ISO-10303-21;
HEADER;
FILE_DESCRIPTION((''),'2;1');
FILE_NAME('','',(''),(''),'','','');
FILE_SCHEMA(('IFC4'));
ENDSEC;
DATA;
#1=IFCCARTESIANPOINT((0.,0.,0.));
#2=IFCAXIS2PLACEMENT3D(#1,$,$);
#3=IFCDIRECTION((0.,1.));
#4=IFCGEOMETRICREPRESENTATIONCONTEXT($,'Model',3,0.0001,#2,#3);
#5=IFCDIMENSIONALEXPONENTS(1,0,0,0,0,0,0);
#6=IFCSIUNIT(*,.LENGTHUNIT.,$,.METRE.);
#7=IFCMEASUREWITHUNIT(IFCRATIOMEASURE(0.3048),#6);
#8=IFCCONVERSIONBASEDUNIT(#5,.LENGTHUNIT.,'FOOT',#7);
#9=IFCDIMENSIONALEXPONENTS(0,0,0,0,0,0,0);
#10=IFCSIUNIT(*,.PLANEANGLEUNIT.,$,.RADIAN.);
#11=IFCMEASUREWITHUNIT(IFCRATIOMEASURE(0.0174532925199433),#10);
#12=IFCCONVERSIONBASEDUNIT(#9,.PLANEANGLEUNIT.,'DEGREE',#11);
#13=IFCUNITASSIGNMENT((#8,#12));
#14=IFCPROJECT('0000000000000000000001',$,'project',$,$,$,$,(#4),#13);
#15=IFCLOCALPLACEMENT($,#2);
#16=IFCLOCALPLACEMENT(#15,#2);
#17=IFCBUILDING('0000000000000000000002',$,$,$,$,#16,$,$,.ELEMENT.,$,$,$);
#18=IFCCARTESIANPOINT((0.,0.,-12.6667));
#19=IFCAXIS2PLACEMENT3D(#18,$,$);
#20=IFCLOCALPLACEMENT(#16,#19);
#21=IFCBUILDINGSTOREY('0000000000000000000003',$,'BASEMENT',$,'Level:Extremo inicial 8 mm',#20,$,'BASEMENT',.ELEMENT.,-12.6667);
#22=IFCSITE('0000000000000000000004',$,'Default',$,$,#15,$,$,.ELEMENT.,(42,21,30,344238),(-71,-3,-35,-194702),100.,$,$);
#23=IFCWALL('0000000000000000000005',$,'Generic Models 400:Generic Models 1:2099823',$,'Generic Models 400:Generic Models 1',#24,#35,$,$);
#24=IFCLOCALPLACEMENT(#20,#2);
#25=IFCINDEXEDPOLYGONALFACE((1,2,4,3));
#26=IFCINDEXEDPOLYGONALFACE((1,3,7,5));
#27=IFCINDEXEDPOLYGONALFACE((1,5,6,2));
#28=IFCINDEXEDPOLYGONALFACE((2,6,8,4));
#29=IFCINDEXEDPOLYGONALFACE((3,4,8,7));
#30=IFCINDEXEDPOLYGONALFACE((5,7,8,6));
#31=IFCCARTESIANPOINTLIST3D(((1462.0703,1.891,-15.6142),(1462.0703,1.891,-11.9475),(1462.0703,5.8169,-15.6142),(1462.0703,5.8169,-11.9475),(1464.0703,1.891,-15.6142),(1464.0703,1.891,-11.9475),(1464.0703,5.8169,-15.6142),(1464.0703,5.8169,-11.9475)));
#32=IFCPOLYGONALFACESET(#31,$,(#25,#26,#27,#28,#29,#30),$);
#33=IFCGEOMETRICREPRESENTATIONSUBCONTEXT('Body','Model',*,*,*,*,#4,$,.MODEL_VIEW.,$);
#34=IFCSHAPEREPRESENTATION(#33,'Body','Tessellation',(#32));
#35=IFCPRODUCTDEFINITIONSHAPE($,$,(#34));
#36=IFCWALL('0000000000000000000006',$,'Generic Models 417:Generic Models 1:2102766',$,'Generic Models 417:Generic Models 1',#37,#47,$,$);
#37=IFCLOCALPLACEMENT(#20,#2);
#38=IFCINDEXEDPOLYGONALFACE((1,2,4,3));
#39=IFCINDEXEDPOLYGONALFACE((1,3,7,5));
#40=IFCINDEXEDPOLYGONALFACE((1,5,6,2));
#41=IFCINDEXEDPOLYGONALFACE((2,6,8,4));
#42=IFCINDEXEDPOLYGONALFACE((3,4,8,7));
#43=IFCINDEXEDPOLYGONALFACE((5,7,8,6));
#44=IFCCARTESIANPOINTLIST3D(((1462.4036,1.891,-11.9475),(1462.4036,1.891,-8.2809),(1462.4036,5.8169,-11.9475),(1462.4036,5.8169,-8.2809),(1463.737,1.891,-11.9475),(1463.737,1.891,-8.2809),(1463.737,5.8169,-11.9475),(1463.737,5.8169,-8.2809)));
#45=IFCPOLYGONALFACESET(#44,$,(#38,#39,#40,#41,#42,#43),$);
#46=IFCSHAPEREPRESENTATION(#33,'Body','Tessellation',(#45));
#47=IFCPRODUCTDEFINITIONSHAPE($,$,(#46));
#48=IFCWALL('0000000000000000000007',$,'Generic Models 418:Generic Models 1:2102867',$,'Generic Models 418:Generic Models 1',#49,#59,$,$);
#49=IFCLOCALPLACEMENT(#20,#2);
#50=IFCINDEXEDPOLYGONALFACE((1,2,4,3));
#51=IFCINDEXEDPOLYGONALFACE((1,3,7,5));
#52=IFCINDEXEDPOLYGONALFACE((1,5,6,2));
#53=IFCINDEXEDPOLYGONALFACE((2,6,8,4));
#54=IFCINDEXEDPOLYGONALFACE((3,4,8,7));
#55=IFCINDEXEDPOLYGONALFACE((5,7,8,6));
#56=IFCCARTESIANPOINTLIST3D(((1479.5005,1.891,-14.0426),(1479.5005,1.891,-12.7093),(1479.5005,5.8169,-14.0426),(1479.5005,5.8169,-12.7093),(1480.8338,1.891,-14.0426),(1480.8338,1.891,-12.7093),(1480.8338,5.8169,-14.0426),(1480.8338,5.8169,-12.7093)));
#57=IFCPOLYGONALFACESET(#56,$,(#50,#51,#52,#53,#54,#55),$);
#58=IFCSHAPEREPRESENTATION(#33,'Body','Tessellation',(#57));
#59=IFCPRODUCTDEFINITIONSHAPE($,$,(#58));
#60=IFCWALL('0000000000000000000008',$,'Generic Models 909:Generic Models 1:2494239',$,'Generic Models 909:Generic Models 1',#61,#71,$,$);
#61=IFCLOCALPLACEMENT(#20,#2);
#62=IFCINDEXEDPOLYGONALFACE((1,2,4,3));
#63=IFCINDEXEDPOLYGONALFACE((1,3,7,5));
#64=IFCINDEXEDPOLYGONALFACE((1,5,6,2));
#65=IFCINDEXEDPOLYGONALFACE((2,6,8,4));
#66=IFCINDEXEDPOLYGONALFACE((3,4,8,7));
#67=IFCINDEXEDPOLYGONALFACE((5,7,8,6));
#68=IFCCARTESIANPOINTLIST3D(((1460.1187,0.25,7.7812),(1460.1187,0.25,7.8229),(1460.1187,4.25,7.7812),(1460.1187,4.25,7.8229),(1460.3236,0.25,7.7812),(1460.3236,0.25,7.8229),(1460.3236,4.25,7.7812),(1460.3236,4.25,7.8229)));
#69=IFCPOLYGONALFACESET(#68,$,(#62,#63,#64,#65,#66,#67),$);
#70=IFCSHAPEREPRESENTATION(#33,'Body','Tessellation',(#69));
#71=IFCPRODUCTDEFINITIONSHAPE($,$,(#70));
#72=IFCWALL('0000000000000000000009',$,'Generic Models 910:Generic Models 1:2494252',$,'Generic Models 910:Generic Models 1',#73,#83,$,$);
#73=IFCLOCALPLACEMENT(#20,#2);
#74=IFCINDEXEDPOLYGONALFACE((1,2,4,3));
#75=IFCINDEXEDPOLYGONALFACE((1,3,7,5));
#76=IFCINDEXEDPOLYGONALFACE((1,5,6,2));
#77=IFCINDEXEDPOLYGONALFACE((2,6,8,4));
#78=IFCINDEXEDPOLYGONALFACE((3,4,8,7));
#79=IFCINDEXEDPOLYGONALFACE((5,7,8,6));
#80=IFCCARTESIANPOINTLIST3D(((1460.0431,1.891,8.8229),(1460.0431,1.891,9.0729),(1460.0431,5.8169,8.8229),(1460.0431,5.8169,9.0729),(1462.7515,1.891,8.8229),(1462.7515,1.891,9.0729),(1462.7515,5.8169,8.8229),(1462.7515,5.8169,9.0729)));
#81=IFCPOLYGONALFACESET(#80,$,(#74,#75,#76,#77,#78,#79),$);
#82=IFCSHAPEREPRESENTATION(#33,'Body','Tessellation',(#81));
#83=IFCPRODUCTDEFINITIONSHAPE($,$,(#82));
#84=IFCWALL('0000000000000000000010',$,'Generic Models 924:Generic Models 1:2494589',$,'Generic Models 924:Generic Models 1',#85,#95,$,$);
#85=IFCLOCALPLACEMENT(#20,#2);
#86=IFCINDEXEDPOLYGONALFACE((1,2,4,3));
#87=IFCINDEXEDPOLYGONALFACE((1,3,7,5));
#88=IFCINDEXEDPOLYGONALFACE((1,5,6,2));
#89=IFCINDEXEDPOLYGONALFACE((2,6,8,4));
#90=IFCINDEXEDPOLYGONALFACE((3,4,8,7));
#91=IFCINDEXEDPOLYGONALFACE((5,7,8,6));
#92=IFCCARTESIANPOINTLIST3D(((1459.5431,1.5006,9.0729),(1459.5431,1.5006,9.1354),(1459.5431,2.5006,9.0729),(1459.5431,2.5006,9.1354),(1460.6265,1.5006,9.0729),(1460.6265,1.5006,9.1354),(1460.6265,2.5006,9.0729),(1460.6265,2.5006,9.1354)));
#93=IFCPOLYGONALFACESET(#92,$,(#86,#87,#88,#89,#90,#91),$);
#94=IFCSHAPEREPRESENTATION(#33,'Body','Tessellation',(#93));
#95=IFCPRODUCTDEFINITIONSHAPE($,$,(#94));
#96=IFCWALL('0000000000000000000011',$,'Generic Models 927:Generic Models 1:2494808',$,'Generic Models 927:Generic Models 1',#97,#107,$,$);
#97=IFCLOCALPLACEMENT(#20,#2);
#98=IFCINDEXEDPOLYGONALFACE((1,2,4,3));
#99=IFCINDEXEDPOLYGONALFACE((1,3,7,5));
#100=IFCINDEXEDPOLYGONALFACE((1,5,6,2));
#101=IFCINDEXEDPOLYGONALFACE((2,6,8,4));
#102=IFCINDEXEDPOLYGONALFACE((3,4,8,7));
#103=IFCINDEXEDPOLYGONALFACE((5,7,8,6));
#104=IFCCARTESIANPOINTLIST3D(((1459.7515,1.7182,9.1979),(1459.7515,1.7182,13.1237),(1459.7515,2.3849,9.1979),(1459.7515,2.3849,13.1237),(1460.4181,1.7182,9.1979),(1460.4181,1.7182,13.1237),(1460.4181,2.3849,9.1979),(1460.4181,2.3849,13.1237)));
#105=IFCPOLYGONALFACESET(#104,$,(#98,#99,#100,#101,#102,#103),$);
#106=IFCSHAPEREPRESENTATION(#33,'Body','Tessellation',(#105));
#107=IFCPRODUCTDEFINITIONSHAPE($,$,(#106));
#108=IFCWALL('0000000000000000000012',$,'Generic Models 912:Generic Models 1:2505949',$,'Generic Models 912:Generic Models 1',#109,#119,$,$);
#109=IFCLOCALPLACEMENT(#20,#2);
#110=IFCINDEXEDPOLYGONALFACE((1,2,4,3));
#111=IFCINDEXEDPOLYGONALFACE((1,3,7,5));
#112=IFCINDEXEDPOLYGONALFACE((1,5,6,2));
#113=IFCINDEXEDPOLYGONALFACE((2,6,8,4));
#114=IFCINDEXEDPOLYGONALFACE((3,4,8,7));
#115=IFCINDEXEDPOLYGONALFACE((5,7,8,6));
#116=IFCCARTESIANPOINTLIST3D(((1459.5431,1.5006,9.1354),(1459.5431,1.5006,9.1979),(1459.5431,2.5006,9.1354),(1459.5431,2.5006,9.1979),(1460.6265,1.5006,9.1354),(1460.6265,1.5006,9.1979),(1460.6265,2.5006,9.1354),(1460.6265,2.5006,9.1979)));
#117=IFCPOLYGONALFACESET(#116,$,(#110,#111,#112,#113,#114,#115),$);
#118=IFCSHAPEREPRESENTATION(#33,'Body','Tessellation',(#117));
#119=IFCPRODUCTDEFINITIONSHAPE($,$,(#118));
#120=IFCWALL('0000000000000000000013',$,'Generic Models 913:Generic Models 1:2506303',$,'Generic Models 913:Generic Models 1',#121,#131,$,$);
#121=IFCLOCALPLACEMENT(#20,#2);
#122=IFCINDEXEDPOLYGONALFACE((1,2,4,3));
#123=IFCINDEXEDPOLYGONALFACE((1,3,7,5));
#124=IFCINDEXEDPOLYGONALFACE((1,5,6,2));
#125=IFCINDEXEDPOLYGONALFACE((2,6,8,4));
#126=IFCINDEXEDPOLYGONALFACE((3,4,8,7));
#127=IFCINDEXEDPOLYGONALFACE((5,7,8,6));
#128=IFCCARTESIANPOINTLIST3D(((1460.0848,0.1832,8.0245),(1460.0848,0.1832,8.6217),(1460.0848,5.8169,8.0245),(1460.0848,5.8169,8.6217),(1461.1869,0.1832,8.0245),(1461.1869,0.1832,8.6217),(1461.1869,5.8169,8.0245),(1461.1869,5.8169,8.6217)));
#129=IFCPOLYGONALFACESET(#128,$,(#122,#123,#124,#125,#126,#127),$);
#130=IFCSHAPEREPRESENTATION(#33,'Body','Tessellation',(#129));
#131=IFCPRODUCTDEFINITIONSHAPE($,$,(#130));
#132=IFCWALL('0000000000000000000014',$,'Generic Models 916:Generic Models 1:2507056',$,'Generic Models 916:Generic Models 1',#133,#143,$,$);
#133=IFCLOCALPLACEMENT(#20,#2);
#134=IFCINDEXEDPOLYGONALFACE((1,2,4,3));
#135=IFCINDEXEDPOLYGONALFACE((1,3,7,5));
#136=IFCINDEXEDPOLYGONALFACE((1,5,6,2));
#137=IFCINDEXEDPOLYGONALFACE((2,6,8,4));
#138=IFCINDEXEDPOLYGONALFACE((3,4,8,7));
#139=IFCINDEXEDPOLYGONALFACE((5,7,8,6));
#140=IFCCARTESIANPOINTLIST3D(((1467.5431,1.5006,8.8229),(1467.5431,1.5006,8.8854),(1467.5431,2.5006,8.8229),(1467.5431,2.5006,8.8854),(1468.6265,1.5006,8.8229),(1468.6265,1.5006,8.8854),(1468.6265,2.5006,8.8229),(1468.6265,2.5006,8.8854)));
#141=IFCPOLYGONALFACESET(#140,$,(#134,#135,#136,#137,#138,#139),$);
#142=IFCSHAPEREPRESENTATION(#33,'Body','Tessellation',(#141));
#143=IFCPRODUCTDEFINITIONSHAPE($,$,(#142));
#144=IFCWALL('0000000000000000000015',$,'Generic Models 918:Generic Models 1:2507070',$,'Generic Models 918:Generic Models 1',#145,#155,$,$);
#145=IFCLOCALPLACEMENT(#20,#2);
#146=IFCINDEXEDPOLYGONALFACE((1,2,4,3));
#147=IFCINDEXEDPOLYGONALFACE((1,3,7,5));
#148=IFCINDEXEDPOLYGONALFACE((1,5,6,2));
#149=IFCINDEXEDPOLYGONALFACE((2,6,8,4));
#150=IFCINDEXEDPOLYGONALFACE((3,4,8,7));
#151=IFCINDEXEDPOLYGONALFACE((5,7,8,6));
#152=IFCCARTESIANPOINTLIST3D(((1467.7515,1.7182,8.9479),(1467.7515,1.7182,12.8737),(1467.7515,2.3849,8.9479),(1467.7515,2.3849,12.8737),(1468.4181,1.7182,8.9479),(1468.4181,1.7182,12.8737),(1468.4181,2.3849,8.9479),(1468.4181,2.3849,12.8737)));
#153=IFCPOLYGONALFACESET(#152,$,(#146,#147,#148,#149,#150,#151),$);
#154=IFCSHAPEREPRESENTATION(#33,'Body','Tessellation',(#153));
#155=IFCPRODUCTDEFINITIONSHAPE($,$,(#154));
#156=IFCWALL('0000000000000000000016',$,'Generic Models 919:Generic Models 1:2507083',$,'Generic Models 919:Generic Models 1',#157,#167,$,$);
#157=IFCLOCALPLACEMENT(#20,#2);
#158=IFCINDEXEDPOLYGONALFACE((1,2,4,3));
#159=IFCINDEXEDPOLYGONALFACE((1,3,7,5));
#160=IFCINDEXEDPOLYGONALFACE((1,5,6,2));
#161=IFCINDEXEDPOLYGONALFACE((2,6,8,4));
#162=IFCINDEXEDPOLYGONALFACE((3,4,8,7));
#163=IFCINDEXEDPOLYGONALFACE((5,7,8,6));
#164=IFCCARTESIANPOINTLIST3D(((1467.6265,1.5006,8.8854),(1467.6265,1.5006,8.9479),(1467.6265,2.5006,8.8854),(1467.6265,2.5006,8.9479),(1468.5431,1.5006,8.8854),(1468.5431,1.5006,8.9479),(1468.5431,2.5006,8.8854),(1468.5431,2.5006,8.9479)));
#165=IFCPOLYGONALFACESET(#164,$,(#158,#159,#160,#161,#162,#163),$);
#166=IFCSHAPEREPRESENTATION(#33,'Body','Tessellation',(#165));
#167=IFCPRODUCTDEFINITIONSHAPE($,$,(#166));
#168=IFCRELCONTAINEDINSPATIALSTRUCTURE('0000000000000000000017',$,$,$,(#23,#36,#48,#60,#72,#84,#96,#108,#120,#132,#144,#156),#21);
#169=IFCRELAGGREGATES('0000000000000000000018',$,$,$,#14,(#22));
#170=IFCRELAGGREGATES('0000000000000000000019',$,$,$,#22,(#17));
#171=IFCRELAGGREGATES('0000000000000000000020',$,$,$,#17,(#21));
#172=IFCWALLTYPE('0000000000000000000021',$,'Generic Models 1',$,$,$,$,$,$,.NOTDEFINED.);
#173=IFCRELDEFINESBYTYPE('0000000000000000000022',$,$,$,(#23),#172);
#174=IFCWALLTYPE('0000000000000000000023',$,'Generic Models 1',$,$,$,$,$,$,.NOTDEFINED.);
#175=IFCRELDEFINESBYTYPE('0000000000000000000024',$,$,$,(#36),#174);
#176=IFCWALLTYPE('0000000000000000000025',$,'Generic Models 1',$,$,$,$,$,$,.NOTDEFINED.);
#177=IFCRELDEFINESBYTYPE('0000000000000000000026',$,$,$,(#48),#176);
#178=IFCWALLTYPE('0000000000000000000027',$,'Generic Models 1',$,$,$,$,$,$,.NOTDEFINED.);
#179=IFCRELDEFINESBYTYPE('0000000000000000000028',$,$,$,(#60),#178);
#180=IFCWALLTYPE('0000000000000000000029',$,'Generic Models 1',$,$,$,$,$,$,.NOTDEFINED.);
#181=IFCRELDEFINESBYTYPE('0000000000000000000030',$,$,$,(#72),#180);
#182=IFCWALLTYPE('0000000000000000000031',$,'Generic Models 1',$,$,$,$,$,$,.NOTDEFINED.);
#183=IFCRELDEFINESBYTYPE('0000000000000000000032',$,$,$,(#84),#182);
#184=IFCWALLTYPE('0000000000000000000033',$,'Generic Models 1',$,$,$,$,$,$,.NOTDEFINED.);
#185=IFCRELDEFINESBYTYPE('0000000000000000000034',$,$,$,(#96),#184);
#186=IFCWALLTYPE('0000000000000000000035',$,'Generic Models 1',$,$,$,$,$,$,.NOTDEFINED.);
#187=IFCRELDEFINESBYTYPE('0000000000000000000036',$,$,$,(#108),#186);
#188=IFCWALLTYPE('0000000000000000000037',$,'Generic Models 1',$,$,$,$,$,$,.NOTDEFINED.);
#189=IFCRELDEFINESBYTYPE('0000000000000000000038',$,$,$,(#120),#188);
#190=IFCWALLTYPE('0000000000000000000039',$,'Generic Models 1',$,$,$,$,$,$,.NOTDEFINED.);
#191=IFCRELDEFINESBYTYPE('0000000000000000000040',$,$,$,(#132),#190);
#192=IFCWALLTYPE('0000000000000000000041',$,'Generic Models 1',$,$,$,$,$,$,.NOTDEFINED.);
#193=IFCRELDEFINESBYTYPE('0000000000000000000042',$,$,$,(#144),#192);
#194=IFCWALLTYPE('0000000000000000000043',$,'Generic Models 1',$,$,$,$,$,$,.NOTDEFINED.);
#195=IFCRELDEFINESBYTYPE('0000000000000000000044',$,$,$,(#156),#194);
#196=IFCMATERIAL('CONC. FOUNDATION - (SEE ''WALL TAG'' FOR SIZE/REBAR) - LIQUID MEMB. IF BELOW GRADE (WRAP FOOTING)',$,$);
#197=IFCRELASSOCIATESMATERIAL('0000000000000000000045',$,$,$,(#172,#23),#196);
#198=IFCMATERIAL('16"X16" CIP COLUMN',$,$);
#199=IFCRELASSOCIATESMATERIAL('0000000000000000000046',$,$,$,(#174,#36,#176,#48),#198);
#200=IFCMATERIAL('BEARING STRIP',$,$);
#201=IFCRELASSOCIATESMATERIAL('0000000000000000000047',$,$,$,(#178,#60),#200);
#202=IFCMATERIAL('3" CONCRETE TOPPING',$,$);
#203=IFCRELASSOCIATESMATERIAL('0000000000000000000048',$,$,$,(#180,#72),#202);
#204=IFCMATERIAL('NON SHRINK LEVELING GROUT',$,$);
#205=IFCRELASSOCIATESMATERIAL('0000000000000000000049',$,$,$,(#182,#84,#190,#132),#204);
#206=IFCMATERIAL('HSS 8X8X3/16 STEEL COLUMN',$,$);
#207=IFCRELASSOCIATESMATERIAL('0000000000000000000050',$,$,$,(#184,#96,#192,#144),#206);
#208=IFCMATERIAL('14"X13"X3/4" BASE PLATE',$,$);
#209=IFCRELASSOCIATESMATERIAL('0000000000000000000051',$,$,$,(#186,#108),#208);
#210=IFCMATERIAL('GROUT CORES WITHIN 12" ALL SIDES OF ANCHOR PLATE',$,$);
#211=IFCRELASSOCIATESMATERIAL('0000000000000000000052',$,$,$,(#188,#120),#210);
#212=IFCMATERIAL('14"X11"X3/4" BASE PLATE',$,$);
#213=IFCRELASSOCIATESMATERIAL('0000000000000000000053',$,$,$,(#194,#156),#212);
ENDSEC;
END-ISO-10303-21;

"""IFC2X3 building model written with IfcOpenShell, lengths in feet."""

from ifc_helpers import new_model, entity, si_unit, converted_unit, direction, frame, frame_2d, origin, place, context, subcontext, project, spatial, rectangle, extrude, material, type_object, element, save


model = new_model("IFC2X3")

# Units and contexts
model_context = context("Model", 3, precision=0.0001, world=origin(), true_north=direction((0.0, 1.0)))
body_context = subcontext(model_context, "Body", "Model", "MODEL_VIEW")
ifc_project = project(units=[converted_unit("LENGTHUNIT", "FOOT", entity("IfcRatioMeasure", 0.3048), si_unit("LENGTHUNIT", "METRE"), dimensions=[1, 0, 0, 0, 0, 0, 0]), converted_unit("PLANEANGLEUNIT", "DEGREE", entity("IfcRatioMeasure", 0.0174532925199433), si_unit("PLANEANGLEUNIT", "RADIAN"), dimensions=[0, 0, 0, 0, 0, 0, 0])], contexts=[model_context])

# Site, building, storey
site_placement = place(None, origin())
site = spatial("IfcSite", under=ifc_project, at=site_placement, Name="Default", CompositionType="ELEMENT", RefLatitude=(42, 21, 30, 344238), RefLongitude=(-71, -3, -35, -194702), RefElevation=100.0)
building_placement = place(site_placement, origin())
building = spatial("IfcBuilding", under=site, at=building_placement, CompositionType="ELEMENT")
storey_placement = place(building_placement, frame((0.0, 0.0, -12.6667)))
storey = spatial("IfcBuildingStorey", under=building, at=storey_placement, Name="BASEMENT", ObjectType="Level:Extremo inicial 8 mm", LongName="BASEMENT", CompositionType="ELEMENT", Elevation=-12.6667)

# Walls
ifc_material_1 = material(Name="CONC. FOUNDATION - (SEE 'WALL TAG' FOR SIZE/REBAR) - LIQUID MEMB. IF BELOW GRADE (WRAP FOOTING)")
wall_type_1 = type_object("IfcWallType", Name="Generic Models 1", PredefinedType="NOTDEFINED", material=ifc_material_1)
wall_1_placement = place(storey_placement, frame((1462.0703, 1.891, -15.6142), z_axis=(0.0, 0.0, 1.0), x_axis=(0.0, 1.0, 0.0)))
element("IfcWall", 1, at=wall_1_placement, inside=storey, type_object=wall_type_1, material=ifc_material_1, Name="Generic Models 400:Generic Models 1:2099823", ObjectType="Generic Models 400:Generic Models 1", context=body_context, shape_type="SweptSolid", body=[
    extrude(rectangle(XDim=3.9258, YDim=2.0, at=frame_2d((0.0, 0.0), x_axis=(1.0, 0.0))), frame((1.9629, -1.0, 0.0)), (0.0, 0.0, 1.0), 3.6667),
])
ifc_material_2 = material(Name="16\"X16\" CIP COLUMN")
wall_type_2 = type_object("IfcWallType", Name="Generic Models 1", PredefinedType="NOTDEFINED", material=ifc_material_2)
wall_2_placement = place(storey_placement, frame((1462.4036, 1.891, -11.9475), z_axis=(0.0, 0.0, 1.0), x_axis=(0.0, 1.0, 0.0)))
element("IfcWall", 2, at=wall_2_placement, inside=storey, type_object=wall_type_2, material=ifc_material_2, Name="Generic Models 417:Generic Models 1:2102766", ObjectType="Generic Models 417:Generic Models 1", context=body_context, shape_type="SweptSolid", body=[
    extrude(rectangle(XDim=3.9258, YDim=1.3333, at=frame_2d((0.0, 0.0), x_axis=(1.0, 0.0))), frame((1.9629, -0.6667, 0.0)), (0.0, 0.0, 1.0), 3.6667),
])
wall_type_3 = type_object("IfcWallType", Name="Generic Models 1", PredefinedType="NOTDEFINED", material=ifc_material_2)
wall_3_placement = place(storey_placement, frame((1479.5005, 1.891, -14.0426), z_axis=(0.0, 0.0, 1.0), x_axis=(0.0, 1.0, 0.0)))
element("IfcWall", 3, at=wall_3_placement, inside=storey, type_object=wall_type_3, material=ifc_material_2, Name="Generic Models 418:Generic Models 1:2102867", ObjectType="Generic Models 418:Generic Models 1", context=body_context, shape_type="SweptSolid", body=[
    extrude(rectangle(XDim=3.9258, YDim=1.3333, at=frame_2d((0.0, 0.0), x_axis=(1.0, 0.0))), frame((1.9629, -0.6667, 0.0)), (0.0, 0.0, 1.0), 1.3333),
])
ifc_material_3 = material(Name="BEARING STRIP")
wall_type_4 = type_object("IfcWallType", Name="Generic Models 1", PredefinedType="NOTDEFINED", material=ifc_material_3)
wall_4_placement = place(storey_placement, frame((1460.1187, 0.25, 7.7812), z_axis=(0.0, 0.0, 1.0), x_axis=(0.0, 1.0, 0.0)))
element("IfcWall", 4, at=wall_4_placement, inside=storey, type_object=wall_type_4, material=ifc_material_3, Name="Generic Models 909:Generic Models 1:2494239", ObjectType="Generic Models 909:Generic Models 1", context=body_context, shape_type="SweptSolid", body=[
    extrude(rectangle(XDim=4.0, YDim=0.205, at=frame_2d((0.0, 0.0), x_axis=(1.0, 0.0))), frame((2.0, -0.1025, 0.0)), (0.0, 0.0, 1.0), 0.0417),
])
ifc_material_4 = material(Name="3\" CONCRETE TOPPING")
wall_type_5 = type_object("IfcWallType", Name="Generic Models 1", PredefinedType="NOTDEFINED", material=ifc_material_4)
wall_5_placement = place(storey_placement, frame((1460.0431, 1.891, 8.8229), z_axis=(0.0, 0.0, 1.0), x_axis=(0.0, 1.0, 0.0)))
element("IfcWall", 5, at=wall_5_placement, inside=storey, type_object=wall_type_5, material=ifc_material_4, Name="Generic Models 910:Generic Models 1:2494252", ObjectType="Generic Models 910:Generic Models 1", context=body_context, shape_type="SweptSolid", body=[
    extrude(rectangle(XDim=3.9258, YDim=2.7083, at=frame_2d((0.0, 0.0), x_axis=(1.0, 0.0))), frame((1.9629, -1.3542, 0.0)), (0.0, 0.0, 1.0), 0.25),
])
ifc_material_5 = material(Name="NON SHRINK LEVELING GROUT")
wall_type_6 = type_object("IfcWallType", Name="Generic Models 1", PredefinedType="NOTDEFINED", material=ifc_material_5)
wall_6_placement = place(storey_placement, frame((1459.5431, 1.5006, 9.0729)))
element("IfcWall", 6, at=wall_6_placement, inside=storey, type_object=wall_type_6, material=ifc_material_5, Name="Generic Models 924:Generic Models 1:2494589", ObjectType="Generic Models 924:Generic Models 1", context=body_context, shape_type="SweptSolid", body=[
    extrude(rectangle(XDim=1.0, YDim=1.0833, at=frame_2d((0.0, 0.0), x_axis=(1.0, 0.0))), frame((0.5417, 0.5, 0.0), z_axis=(0.0, 0.0, 1.0), x_axis=(0.0, 1.0, 0.0)), (0.0, 0.0, 1.0), 0.0625),
])
ifc_material_6 = material(Name="HSS 8X8X3/16 STEEL COLUMN")
wall_type_7 = type_object("IfcWallType", Name="Generic Models 1", PredefinedType="NOTDEFINED", material=ifc_material_6)
wall_7_placement = place(storey_placement, frame((1459.7515, 1.7182, 9.1979), z_axis=(0.0, 0.0, 1.0), x_axis=(0.0, 1.0, 0.0)))
element("IfcWall", 7, at=wall_7_placement, inside=storey, type_object=wall_type_7, material=ifc_material_6, Name="Generic Models 927:Generic Models 1:2494808", ObjectType="Generic Models 927:Generic Models 1", context=body_context, shape_type="SweptSolid", body=[
    extrude(rectangle(XDim=0.6667, YDim=0.6667, at=frame_2d((0.0, 0.0), x_axis=(1.0, 0.0))), frame((0.3333, -0.3333, 0.0), z_axis=(0.0, 0.0, 1.0), x_axis=(-1.0, 0.0, 0.0)), (0.0, 0.0, 1.0), 3.9258),
])
ifc_material_7 = material(Name="14\"X13\"X3/4\" BASE PLATE")
wall_type_8 = type_object("IfcWallType", Name="Generic Models 1", PredefinedType="NOTDEFINED", material=ifc_material_7)
wall_8_placement = place(storey_placement, frame((1459.5431, 1.5006, 9.1354)))
element("IfcWall", 8, at=wall_8_placement, inside=storey, type_object=wall_type_8, material=ifc_material_7, Name="Generic Models 912:Generic Models 1:2505949", ObjectType="Generic Models 912:Generic Models 1", context=body_context, shape_type="SweptSolid", body=[
    extrude(rectangle(XDim=1.0, YDim=1.0833, at=frame_2d((0.0, 0.0), x_axis=(1.0, 0.0))), frame((0.5417, 0.5, 0.0), z_axis=(0.0, 0.0, 1.0), x_axis=(0.0, 1.0, 0.0)), (0.0, 0.0, 1.0), 0.0625),
])
ifc_material_8 = material(Name="GROUT CORES WITHIN 12\" ALL SIDES OF ANCHOR PLATE")
wall_type_9 = type_object("IfcWallType", Name="Generic Models 1", PredefinedType="NOTDEFINED", material=ifc_material_8)
wall_9_placement = place(storey_placement, frame((1460.0848, 0.1832, 8.0245), z_axis=(0.0, 0.0, 1.0), x_axis=(0.0, 1.0, 0.0)))
element("IfcWall", 9, at=wall_9_placement, inside=storey, type_object=wall_type_9, material=ifc_material_8, Name="Generic Models 913:Generic Models 1:2506303", ObjectType="Generic Models 913:Generic Models 1", context=body_context, shape_type="SweptSolid", body=[
    extrude(rectangle(XDim=5.6337, YDim=1.1021, at=frame_2d((0.0, 0.0), x_axis=(1.0, 0.0))), frame((2.8168, -0.5511, 0.0)), (0.0, 0.0, 1.0), 0.5972),
])
wall_type_10 = type_object("IfcWallType", Name="Generic Models 1", PredefinedType="NOTDEFINED", material=ifc_material_5)
wall_10_placement = place(storey_placement, frame((1467.5431, 1.5006, 8.8229)))
element("IfcWall", 10, at=wall_10_placement, inside=storey, type_object=wall_type_10, material=ifc_material_5, Name="Generic Models 916:Generic Models 1:2507056", ObjectType="Generic Models 916:Generic Models 1", context=body_context, shape_type="SweptSolid", body=[
    extrude(rectangle(XDim=1.0, YDim=1.0833, at=frame_2d((0.0, 0.0), x_axis=(1.0, 0.0))), frame((0.5417, 0.5, 0.0), z_axis=(0.0, 0.0, 1.0), x_axis=(0.0, 1.0, 0.0)), (0.0, 0.0, 1.0), 0.0625),
])
wall_type_11 = type_object("IfcWallType", Name="Generic Models 1", PredefinedType="NOTDEFINED", material=ifc_material_6)
wall_11_placement = place(storey_placement, frame((1467.7515, 1.7182, 8.9479), z_axis=(0.0, 0.0, 1.0), x_axis=(0.0, 1.0, 0.0)))
element("IfcWall", 11, at=wall_11_placement, inside=storey, type_object=wall_type_11, material=ifc_material_6, Name="Generic Models 918:Generic Models 1:2507070", ObjectType="Generic Models 918:Generic Models 1", context=body_context, shape_type="SweptSolid", body=[
    extrude(rectangle(XDim=0.6667, YDim=0.6667, at=frame_2d((0.0, 0.0), x_axis=(1.0, 0.0))), frame((0.3333, -0.3333, 0.0), z_axis=(0.0, 0.0, 1.0), x_axis=(-1.0, 0.0, 0.0)), (0.0, 0.0, 1.0), 3.9258),
])
ifc_material_9 = material(Name="14\"X11\"X3/4\" BASE PLATE")
wall_type_12 = type_object("IfcWallType", Name="Generic Models 1", PredefinedType="NOTDEFINED", material=ifc_material_9)
wall_12_placement = place(storey_placement, frame((1467.6265, 1.5006, 8.8854), z_axis=(0.0, 0.0, 1.0), x_axis=(0.0, 1.0, 0.0)))
element("IfcWall", 12, at=wall_12_placement, inside=storey, type_object=wall_type_12, material=ifc_material_9, Name="Generic Models 919:Generic Models 1:2507083", ObjectType="Generic Models 919:Generic Models 1", context=body_context, shape_type="SweptSolid", body=[
    extrude(rectangle(XDim=1.0, YDim=0.9167, at=frame_2d((0.0, 0.0), x_axis=(1.0, 0.0))), frame((0.5, -0.4583, 0.0)), (0.0, 0.0, 1.0), 0.0625),
])

save(model, "model.ifc")
